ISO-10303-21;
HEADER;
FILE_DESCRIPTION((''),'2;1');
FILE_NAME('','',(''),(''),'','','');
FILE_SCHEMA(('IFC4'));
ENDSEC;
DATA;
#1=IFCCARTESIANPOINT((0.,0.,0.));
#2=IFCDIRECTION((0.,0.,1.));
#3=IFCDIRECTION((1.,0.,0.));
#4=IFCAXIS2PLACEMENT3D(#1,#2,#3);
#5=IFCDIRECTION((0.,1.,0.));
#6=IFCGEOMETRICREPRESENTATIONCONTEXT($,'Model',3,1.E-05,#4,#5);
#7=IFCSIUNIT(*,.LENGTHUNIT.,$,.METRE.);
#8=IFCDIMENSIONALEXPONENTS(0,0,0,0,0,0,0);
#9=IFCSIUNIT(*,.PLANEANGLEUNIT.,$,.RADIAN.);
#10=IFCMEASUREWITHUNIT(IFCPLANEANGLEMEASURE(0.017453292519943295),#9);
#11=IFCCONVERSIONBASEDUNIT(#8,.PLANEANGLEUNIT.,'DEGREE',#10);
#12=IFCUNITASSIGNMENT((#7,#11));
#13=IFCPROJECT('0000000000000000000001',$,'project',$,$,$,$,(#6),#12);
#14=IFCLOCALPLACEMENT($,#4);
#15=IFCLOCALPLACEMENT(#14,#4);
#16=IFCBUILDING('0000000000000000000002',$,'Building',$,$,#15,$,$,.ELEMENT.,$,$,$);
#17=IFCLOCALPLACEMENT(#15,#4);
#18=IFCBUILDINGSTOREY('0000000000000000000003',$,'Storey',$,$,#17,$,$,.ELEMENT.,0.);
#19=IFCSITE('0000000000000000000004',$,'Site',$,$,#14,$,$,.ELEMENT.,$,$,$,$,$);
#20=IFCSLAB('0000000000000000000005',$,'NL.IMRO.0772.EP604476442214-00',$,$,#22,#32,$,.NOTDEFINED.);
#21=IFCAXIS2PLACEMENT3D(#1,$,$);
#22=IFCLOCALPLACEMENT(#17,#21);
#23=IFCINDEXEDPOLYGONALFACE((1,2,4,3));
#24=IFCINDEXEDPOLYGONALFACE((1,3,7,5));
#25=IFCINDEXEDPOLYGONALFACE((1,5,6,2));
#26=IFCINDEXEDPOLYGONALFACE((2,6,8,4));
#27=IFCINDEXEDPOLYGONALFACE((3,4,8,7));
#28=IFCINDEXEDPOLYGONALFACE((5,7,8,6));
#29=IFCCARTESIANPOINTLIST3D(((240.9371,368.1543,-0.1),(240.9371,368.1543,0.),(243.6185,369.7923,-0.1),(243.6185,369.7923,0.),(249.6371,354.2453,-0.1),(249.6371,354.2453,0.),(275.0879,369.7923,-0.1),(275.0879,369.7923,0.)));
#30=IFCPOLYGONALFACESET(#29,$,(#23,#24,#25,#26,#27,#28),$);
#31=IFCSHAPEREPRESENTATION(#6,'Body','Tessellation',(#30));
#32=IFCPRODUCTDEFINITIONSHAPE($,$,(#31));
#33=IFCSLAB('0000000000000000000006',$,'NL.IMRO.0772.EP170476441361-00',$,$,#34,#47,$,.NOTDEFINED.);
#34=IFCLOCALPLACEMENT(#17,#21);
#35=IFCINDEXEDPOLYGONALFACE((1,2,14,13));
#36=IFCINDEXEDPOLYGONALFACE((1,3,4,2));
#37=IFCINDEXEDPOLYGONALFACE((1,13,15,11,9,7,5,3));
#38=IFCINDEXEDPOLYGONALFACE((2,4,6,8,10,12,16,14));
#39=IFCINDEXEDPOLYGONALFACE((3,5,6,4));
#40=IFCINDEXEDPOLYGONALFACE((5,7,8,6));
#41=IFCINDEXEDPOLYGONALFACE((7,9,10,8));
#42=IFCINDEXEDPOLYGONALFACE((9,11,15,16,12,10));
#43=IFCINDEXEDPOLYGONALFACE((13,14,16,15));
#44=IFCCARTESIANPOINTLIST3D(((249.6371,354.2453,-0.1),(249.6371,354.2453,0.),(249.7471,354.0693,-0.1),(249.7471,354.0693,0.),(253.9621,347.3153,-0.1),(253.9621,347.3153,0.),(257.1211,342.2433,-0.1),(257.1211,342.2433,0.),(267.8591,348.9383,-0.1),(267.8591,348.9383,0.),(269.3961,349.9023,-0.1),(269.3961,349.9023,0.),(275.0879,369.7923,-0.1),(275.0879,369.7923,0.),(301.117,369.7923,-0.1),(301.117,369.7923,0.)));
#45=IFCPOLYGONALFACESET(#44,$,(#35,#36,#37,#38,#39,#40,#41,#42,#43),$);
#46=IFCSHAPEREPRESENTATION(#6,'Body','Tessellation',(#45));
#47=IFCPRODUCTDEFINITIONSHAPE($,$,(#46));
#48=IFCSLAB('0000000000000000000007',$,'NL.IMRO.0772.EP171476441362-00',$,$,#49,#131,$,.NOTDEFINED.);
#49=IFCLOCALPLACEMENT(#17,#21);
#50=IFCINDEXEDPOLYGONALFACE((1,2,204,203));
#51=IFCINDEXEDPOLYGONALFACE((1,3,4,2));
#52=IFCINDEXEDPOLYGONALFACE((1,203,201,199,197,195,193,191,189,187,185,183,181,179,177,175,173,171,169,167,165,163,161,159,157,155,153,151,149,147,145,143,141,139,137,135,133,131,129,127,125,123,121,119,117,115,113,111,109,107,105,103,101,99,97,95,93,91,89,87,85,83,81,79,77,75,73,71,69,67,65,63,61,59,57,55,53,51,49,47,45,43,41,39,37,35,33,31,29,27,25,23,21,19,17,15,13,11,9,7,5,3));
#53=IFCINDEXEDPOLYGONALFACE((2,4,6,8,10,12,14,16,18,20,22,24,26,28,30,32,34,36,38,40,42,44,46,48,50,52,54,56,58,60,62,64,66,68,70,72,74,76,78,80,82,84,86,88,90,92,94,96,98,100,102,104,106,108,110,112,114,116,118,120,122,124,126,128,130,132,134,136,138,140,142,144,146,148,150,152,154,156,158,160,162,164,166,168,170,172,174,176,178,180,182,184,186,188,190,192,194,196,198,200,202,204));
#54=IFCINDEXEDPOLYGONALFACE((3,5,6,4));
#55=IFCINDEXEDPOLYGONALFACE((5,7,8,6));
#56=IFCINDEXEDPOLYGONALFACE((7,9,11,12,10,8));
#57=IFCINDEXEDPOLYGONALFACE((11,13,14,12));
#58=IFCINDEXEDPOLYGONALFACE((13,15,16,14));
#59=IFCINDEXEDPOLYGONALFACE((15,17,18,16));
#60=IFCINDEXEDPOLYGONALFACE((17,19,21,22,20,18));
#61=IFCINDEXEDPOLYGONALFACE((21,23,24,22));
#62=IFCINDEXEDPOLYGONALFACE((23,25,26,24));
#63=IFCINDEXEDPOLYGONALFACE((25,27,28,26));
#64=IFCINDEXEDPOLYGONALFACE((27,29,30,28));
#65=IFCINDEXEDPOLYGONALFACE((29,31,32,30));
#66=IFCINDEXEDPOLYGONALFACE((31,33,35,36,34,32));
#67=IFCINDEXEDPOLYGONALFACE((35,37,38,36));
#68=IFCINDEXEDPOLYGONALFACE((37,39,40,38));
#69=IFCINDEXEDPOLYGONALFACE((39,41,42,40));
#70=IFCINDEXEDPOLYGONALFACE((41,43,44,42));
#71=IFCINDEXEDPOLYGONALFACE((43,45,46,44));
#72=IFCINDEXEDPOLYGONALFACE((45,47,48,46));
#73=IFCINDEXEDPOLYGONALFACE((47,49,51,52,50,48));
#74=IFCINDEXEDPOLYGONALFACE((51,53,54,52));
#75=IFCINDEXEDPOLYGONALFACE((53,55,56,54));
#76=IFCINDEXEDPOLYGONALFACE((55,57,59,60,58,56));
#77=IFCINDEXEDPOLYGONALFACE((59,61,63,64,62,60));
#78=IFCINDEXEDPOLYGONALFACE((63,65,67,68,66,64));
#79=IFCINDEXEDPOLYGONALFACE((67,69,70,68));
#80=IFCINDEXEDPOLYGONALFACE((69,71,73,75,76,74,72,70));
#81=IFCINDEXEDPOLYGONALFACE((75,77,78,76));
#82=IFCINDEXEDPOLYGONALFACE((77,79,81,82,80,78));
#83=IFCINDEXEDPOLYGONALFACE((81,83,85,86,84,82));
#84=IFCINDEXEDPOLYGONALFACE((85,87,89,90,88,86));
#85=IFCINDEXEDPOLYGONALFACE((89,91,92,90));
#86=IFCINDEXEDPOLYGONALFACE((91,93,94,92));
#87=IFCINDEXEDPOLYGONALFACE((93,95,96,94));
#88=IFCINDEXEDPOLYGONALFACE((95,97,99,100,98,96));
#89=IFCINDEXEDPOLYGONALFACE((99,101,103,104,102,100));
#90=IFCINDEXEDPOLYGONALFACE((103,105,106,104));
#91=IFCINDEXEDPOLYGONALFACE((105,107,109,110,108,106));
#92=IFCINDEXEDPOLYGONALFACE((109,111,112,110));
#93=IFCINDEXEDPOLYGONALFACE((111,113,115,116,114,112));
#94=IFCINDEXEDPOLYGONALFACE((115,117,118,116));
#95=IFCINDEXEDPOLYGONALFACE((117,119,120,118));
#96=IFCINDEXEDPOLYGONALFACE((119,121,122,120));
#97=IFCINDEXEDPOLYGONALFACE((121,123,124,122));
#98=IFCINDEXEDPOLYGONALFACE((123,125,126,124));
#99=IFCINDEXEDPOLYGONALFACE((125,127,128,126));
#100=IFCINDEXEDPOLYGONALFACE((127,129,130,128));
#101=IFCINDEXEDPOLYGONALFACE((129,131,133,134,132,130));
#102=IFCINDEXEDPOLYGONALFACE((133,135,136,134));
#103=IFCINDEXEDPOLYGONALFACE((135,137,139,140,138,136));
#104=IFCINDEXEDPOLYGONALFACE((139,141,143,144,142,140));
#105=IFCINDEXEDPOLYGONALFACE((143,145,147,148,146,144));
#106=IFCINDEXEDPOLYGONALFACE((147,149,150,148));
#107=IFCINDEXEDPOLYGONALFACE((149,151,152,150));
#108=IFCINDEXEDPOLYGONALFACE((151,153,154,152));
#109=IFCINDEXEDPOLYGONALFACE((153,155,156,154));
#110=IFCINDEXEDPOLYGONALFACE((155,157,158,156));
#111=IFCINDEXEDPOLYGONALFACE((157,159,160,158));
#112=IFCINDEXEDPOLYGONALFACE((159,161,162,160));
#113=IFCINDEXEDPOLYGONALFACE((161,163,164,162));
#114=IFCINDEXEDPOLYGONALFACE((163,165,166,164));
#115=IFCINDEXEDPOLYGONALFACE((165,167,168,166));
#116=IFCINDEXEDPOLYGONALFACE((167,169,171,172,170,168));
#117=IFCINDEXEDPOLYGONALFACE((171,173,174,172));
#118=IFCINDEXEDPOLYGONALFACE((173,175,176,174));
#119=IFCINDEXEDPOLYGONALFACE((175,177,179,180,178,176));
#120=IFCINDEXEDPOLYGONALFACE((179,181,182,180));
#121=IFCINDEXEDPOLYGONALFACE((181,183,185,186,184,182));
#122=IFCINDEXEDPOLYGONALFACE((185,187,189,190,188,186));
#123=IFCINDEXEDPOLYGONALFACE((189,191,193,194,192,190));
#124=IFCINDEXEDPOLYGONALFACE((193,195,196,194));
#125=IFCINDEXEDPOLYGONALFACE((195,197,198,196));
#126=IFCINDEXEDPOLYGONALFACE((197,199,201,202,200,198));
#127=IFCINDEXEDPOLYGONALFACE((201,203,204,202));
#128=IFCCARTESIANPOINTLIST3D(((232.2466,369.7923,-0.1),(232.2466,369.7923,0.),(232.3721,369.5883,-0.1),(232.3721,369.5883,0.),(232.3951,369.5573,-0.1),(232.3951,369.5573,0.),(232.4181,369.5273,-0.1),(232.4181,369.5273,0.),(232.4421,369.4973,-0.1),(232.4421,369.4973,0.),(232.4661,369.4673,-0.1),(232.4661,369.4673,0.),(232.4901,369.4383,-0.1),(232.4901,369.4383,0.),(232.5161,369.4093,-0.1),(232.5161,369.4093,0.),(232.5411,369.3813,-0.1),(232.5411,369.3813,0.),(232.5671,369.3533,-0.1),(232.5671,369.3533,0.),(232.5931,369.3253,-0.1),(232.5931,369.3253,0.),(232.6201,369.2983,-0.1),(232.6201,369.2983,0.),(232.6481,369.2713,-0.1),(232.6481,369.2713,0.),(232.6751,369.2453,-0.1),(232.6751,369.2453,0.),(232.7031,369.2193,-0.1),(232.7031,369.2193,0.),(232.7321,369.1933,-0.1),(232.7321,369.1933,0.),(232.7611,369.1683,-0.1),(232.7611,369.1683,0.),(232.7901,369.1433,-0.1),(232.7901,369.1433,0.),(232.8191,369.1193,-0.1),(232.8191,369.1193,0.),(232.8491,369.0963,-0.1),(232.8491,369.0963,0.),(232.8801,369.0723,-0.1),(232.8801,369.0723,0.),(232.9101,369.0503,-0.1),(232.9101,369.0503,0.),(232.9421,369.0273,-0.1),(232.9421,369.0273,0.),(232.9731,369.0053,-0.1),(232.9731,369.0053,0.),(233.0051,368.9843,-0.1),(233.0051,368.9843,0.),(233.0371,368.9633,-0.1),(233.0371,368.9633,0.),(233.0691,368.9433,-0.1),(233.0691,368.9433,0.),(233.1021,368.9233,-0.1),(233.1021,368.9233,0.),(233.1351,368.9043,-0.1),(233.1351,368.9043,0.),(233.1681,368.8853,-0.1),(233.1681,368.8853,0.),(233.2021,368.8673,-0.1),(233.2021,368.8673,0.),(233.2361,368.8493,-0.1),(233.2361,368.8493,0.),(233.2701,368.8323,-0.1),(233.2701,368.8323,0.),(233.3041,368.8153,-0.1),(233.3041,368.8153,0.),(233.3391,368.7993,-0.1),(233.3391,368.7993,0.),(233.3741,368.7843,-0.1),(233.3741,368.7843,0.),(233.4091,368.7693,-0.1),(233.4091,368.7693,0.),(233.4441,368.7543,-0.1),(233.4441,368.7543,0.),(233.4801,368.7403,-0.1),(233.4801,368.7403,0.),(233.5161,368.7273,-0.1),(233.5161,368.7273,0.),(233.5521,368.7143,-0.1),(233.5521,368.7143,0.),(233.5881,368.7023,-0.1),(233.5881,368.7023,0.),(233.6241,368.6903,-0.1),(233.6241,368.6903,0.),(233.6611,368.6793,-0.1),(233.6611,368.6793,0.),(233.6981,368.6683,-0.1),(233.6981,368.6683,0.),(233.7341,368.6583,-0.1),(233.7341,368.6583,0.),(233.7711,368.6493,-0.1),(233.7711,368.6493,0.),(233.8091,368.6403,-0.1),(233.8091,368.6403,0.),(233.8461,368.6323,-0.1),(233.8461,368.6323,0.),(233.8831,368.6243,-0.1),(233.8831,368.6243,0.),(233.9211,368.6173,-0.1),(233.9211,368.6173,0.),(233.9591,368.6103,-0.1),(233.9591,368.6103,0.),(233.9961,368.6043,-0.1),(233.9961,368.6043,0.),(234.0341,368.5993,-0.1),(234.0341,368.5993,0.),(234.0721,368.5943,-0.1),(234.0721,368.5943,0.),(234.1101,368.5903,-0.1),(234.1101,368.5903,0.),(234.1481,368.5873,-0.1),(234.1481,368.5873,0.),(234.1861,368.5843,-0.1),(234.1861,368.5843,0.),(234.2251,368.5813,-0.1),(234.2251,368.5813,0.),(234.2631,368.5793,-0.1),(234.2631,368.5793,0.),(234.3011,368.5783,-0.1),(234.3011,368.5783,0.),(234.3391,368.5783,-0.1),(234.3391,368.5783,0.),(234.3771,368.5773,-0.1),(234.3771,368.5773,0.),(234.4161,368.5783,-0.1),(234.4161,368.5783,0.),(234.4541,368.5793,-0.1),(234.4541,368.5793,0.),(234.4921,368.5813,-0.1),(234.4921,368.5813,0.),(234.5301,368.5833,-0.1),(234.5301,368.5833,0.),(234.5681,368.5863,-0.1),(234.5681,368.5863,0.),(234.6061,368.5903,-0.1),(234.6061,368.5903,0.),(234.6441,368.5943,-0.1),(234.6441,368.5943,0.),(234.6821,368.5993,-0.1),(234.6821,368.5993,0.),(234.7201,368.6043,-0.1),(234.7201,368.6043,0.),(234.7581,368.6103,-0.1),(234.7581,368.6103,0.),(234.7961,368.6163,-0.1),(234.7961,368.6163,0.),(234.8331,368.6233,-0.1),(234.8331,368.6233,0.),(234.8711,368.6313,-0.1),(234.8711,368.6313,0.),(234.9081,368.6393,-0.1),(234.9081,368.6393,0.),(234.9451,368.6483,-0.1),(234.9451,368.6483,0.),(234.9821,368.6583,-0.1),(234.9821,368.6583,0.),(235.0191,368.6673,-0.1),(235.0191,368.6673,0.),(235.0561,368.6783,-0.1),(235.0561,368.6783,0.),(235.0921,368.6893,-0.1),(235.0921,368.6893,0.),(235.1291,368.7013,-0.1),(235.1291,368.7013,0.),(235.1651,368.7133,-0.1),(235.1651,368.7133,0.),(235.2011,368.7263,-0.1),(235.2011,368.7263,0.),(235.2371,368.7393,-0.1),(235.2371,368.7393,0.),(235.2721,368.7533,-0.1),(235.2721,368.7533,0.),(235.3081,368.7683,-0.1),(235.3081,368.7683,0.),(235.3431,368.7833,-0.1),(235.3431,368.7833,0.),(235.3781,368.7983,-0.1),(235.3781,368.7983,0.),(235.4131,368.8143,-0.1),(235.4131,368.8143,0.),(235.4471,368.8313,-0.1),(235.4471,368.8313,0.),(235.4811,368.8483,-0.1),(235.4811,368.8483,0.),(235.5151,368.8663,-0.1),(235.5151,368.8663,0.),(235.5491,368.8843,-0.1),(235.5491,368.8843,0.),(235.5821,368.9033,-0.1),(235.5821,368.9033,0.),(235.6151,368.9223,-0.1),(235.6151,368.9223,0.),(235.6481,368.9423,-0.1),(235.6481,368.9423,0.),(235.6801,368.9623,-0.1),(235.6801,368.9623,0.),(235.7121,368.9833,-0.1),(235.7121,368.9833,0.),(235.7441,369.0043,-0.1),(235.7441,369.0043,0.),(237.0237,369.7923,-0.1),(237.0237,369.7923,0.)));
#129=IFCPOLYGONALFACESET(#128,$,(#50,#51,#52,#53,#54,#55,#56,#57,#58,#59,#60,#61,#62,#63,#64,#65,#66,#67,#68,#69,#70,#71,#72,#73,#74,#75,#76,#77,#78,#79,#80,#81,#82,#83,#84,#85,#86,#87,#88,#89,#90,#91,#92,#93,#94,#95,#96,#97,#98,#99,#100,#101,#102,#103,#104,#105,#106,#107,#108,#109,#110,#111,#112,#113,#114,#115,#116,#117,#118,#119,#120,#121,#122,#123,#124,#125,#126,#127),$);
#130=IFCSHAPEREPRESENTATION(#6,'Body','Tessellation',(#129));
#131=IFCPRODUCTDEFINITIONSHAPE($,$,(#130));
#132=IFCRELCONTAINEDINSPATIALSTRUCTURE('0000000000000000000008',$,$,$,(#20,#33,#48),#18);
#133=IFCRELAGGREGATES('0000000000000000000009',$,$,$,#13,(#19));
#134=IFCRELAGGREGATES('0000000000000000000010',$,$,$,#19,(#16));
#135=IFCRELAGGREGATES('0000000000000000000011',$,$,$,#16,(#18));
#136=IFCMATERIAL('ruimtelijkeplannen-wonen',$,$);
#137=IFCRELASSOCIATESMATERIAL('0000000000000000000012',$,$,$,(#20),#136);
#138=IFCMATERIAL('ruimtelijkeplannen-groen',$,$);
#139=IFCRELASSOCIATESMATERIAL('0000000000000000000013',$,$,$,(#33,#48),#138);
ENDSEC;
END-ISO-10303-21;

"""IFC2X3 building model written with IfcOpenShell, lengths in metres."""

from ifc_helpers import new_model, entity, si_unit, converted_unit, direction, frame, origin_with_axes, place, context, project, spatial, polyline, outline, extrude, material, element, save


model = new_model("IFC2X3")

# Units and contexts
model_context = context("Model", 3, precision=1e-05, world=origin_with_axes(), true_north=direction((0.0, 1.0, 0.0)))
ifc_project = project(units=[si_unit("LENGTHUNIT", "METRE"), converted_unit("PLANEANGLEUNIT", "DEGREE", entity("IfcPlaneAngleMeasure", 0.017453292519943295), si_unit("PLANEANGLEUNIT", "RADIAN"), dimensions=[0, 0, 0, 0, 0, 0, 0])], contexts=[model_context])

# Site, building, storey
site_placement = place(None, origin_with_axes())
site = spatial("IfcSite", under=ifc_project, at=site_placement, Name="Site", CompositionType="ELEMENT")
building_placement = place(site_placement, origin_with_axes())
building = spatial("IfcBuilding", under=site, at=building_placement, Name="Building", CompositionType="ELEMENT")
storey_placement = place(building_placement, origin_with_axes())
storey = spatial("IfcBuildingStorey", under=building, at=storey_placement, Name="Storey", CompositionType="ELEMENT", Elevation=0.0)

# Slabs
ifc_material_1 = material(Name="ruimtelijkeplannen-wonen")
slab_1_placement = place(storey_placement, frame((0.0, 0.0, -0.1), z_axis=(0.0, 0.0, 1.0), x_axis=(1.0, 0.0, 0.0)))
element("IfcSlab", 1, at=slab_1_placement, inside=storey, material=ifc_material_1, Name="NL.IMRO.0772.EP604476442214-00", PredefinedType="NOTDEFINED", context=model_context, shape_type="SweptSolid", body=[
    extrude(outline(polyline([(249.6371, 354.2453), (240.9371, 368.1543), (243.6185, 369.7923), (275.0879, 369.7923), (249.6371, 354.2453)])), origin_with_axes(), (0.0, 0.0, 1.0), 0.1),
])
ifc_material_2 = material(Name="ruimtelijkeplannen-groen")
slab_2_placement = place(storey_placement, frame((0.0, 0.0, -0.1), z_axis=(0.0, 0.0, 1.0), x_axis=(1.0, 0.0, 0.0)))
element("IfcSlab", 2, at=slab_2_placement, inside=storey, material=ifc_material_2, Name="NL.IMRO.0772.EP170476441361-00", PredefinedType="NOTDEFINED", context=model_context, shape_type="SweptSolid", body=[
    extrude(outline(polyline([(269.3961, 349.9023), (267.8591, 348.9383), (257.1211, 342.2433), (253.9621, 347.3153), (249.7471, 354.0693), (249.6371, 354.2453), (275.0879, 369.7923), (301.117, 369.7923), (269.3961, 349.9023)])), origin_with_axes(), (0.0, 0.0, 1.0), 0.1),
])
slab_3_placement = place(storey_placement, frame((0.0, 0.0, -0.1), z_axis=(0.0, 0.0, 1.0), x_axis=(1.0, 0.0, 0.0)))
element("IfcSlab", 3, at=slab_3_placement, inside=storey, material=ifc_material_2, Name="NL.IMRO.0772.EP171476441362-00", PredefinedType="NOTDEFINED", context=model_context, shape_type="SweptSolid", body=[
    extrude(outline(polyline([(235.7441, 369.0043), (235.7121, 368.9833), (235.6801, 368.9623), (235.6481, 368.9423), (235.6151, 368.9223), (235.5821, 368.9033), (235.5491, 368.8843), (235.5151, 368.8663), (235.4811, 368.8483), (235.4471, 368.8313), (235.4131, 368.8143), (235.3781, 368.7983), (235.3431, 368.7833), (235.3081, 368.7683), (235.2721, 368.7533), (235.2371, 368.7393), (235.2011, 368.7263), (235.1651, 368.7133), (235.1291, 368.7013), (235.0921, 368.6893), (235.0561, 368.6783), (235.0191, 368.6673), (234.9821, 368.6583), (234.9451, 368.6483), (234.9081, 368.6393), (234.8711, 368.6313), (234.8331, 368.6233), (234.7961, 368.6163), (234.7581, 368.6103), (234.7201, 368.6043), (234.6821, 368.5993), (234.6441, 368.5943), (234.6061, 368.5903), (234.5681, 368.5863), (234.5301, 368.5833), (234.4921, 368.5813), (234.4541, 368.5793), (234.4161, 368.5783), (234.3771, 368.5773), (234.3391, 368.5783), (234.3011, 368.5783), (234.2631, 368.5793), (234.2251, 368.5813), (234.1861, 368.5843), (234.1481, 368.5873), (234.1101, 368.5903), (234.0721, 368.5943), (234.0341, 368.5993), (233.9961, 368.6043), (233.9591, 368.6103), (233.9211, 368.6173), (233.8831, 368.6243), (233.8461, 368.6323), (233.8091, 368.6403), (233.7711, 368.6493), (233.7341, 368.6583), (233.6981, 368.6683), (233.6611, 368.6793), (233.6241, 368.6903), (233.5881, 368.7023), (233.5521, 368.7143), (233.5161, 368.7273), (233.4801, 368.7403), (233.4441, 368.7543), (233.4091, 368.7693), (233.3741, 368.7843), (233.3391, 368.7993), (233.3041, 368.8153), (233.2701, 368.8323), (233.2361, 368.8493), (233.2021, 368.8673), (233.1681, 368.8853), (233.1351, 368.9043), (233.1021, 368.9233), (233.0691, 368.9433), (233.0371, 368.9633), (233.0051, 368.9843), (232.9731, 369.0053), (232.9421, 369.0273), (232.9101, 369.0503), (232.8801, 369.0723), (232.8491, 369.0963), (232.8191, 369.1193), (232.7901, 369.1433), (232.7611, 369.1683), (232.7321, 369.1933), (232.7031, 369.2193), (232.6751, 369.2453), (232.6481, 369.2713), (232.6201, 369.2983), (232.5931, 369.3253), (232.5671, 369.3533), (232.5411, 369.3813), (232.5161, 369.4093), (232.4901, 369.4383), (232.4661, 369.4673), (232.4421, 369.4973), (232.4181, 369.5273), (232.3951, 369.5573), (232.3721, 369.5883), (232.2466, 369.7923), (237.0237, 369.7923), (235.7441, 369.0043)])), origin_with_axes(), (0.0, 0.0, 1.0), 0.1),
])

save(model, "model.ifc")
